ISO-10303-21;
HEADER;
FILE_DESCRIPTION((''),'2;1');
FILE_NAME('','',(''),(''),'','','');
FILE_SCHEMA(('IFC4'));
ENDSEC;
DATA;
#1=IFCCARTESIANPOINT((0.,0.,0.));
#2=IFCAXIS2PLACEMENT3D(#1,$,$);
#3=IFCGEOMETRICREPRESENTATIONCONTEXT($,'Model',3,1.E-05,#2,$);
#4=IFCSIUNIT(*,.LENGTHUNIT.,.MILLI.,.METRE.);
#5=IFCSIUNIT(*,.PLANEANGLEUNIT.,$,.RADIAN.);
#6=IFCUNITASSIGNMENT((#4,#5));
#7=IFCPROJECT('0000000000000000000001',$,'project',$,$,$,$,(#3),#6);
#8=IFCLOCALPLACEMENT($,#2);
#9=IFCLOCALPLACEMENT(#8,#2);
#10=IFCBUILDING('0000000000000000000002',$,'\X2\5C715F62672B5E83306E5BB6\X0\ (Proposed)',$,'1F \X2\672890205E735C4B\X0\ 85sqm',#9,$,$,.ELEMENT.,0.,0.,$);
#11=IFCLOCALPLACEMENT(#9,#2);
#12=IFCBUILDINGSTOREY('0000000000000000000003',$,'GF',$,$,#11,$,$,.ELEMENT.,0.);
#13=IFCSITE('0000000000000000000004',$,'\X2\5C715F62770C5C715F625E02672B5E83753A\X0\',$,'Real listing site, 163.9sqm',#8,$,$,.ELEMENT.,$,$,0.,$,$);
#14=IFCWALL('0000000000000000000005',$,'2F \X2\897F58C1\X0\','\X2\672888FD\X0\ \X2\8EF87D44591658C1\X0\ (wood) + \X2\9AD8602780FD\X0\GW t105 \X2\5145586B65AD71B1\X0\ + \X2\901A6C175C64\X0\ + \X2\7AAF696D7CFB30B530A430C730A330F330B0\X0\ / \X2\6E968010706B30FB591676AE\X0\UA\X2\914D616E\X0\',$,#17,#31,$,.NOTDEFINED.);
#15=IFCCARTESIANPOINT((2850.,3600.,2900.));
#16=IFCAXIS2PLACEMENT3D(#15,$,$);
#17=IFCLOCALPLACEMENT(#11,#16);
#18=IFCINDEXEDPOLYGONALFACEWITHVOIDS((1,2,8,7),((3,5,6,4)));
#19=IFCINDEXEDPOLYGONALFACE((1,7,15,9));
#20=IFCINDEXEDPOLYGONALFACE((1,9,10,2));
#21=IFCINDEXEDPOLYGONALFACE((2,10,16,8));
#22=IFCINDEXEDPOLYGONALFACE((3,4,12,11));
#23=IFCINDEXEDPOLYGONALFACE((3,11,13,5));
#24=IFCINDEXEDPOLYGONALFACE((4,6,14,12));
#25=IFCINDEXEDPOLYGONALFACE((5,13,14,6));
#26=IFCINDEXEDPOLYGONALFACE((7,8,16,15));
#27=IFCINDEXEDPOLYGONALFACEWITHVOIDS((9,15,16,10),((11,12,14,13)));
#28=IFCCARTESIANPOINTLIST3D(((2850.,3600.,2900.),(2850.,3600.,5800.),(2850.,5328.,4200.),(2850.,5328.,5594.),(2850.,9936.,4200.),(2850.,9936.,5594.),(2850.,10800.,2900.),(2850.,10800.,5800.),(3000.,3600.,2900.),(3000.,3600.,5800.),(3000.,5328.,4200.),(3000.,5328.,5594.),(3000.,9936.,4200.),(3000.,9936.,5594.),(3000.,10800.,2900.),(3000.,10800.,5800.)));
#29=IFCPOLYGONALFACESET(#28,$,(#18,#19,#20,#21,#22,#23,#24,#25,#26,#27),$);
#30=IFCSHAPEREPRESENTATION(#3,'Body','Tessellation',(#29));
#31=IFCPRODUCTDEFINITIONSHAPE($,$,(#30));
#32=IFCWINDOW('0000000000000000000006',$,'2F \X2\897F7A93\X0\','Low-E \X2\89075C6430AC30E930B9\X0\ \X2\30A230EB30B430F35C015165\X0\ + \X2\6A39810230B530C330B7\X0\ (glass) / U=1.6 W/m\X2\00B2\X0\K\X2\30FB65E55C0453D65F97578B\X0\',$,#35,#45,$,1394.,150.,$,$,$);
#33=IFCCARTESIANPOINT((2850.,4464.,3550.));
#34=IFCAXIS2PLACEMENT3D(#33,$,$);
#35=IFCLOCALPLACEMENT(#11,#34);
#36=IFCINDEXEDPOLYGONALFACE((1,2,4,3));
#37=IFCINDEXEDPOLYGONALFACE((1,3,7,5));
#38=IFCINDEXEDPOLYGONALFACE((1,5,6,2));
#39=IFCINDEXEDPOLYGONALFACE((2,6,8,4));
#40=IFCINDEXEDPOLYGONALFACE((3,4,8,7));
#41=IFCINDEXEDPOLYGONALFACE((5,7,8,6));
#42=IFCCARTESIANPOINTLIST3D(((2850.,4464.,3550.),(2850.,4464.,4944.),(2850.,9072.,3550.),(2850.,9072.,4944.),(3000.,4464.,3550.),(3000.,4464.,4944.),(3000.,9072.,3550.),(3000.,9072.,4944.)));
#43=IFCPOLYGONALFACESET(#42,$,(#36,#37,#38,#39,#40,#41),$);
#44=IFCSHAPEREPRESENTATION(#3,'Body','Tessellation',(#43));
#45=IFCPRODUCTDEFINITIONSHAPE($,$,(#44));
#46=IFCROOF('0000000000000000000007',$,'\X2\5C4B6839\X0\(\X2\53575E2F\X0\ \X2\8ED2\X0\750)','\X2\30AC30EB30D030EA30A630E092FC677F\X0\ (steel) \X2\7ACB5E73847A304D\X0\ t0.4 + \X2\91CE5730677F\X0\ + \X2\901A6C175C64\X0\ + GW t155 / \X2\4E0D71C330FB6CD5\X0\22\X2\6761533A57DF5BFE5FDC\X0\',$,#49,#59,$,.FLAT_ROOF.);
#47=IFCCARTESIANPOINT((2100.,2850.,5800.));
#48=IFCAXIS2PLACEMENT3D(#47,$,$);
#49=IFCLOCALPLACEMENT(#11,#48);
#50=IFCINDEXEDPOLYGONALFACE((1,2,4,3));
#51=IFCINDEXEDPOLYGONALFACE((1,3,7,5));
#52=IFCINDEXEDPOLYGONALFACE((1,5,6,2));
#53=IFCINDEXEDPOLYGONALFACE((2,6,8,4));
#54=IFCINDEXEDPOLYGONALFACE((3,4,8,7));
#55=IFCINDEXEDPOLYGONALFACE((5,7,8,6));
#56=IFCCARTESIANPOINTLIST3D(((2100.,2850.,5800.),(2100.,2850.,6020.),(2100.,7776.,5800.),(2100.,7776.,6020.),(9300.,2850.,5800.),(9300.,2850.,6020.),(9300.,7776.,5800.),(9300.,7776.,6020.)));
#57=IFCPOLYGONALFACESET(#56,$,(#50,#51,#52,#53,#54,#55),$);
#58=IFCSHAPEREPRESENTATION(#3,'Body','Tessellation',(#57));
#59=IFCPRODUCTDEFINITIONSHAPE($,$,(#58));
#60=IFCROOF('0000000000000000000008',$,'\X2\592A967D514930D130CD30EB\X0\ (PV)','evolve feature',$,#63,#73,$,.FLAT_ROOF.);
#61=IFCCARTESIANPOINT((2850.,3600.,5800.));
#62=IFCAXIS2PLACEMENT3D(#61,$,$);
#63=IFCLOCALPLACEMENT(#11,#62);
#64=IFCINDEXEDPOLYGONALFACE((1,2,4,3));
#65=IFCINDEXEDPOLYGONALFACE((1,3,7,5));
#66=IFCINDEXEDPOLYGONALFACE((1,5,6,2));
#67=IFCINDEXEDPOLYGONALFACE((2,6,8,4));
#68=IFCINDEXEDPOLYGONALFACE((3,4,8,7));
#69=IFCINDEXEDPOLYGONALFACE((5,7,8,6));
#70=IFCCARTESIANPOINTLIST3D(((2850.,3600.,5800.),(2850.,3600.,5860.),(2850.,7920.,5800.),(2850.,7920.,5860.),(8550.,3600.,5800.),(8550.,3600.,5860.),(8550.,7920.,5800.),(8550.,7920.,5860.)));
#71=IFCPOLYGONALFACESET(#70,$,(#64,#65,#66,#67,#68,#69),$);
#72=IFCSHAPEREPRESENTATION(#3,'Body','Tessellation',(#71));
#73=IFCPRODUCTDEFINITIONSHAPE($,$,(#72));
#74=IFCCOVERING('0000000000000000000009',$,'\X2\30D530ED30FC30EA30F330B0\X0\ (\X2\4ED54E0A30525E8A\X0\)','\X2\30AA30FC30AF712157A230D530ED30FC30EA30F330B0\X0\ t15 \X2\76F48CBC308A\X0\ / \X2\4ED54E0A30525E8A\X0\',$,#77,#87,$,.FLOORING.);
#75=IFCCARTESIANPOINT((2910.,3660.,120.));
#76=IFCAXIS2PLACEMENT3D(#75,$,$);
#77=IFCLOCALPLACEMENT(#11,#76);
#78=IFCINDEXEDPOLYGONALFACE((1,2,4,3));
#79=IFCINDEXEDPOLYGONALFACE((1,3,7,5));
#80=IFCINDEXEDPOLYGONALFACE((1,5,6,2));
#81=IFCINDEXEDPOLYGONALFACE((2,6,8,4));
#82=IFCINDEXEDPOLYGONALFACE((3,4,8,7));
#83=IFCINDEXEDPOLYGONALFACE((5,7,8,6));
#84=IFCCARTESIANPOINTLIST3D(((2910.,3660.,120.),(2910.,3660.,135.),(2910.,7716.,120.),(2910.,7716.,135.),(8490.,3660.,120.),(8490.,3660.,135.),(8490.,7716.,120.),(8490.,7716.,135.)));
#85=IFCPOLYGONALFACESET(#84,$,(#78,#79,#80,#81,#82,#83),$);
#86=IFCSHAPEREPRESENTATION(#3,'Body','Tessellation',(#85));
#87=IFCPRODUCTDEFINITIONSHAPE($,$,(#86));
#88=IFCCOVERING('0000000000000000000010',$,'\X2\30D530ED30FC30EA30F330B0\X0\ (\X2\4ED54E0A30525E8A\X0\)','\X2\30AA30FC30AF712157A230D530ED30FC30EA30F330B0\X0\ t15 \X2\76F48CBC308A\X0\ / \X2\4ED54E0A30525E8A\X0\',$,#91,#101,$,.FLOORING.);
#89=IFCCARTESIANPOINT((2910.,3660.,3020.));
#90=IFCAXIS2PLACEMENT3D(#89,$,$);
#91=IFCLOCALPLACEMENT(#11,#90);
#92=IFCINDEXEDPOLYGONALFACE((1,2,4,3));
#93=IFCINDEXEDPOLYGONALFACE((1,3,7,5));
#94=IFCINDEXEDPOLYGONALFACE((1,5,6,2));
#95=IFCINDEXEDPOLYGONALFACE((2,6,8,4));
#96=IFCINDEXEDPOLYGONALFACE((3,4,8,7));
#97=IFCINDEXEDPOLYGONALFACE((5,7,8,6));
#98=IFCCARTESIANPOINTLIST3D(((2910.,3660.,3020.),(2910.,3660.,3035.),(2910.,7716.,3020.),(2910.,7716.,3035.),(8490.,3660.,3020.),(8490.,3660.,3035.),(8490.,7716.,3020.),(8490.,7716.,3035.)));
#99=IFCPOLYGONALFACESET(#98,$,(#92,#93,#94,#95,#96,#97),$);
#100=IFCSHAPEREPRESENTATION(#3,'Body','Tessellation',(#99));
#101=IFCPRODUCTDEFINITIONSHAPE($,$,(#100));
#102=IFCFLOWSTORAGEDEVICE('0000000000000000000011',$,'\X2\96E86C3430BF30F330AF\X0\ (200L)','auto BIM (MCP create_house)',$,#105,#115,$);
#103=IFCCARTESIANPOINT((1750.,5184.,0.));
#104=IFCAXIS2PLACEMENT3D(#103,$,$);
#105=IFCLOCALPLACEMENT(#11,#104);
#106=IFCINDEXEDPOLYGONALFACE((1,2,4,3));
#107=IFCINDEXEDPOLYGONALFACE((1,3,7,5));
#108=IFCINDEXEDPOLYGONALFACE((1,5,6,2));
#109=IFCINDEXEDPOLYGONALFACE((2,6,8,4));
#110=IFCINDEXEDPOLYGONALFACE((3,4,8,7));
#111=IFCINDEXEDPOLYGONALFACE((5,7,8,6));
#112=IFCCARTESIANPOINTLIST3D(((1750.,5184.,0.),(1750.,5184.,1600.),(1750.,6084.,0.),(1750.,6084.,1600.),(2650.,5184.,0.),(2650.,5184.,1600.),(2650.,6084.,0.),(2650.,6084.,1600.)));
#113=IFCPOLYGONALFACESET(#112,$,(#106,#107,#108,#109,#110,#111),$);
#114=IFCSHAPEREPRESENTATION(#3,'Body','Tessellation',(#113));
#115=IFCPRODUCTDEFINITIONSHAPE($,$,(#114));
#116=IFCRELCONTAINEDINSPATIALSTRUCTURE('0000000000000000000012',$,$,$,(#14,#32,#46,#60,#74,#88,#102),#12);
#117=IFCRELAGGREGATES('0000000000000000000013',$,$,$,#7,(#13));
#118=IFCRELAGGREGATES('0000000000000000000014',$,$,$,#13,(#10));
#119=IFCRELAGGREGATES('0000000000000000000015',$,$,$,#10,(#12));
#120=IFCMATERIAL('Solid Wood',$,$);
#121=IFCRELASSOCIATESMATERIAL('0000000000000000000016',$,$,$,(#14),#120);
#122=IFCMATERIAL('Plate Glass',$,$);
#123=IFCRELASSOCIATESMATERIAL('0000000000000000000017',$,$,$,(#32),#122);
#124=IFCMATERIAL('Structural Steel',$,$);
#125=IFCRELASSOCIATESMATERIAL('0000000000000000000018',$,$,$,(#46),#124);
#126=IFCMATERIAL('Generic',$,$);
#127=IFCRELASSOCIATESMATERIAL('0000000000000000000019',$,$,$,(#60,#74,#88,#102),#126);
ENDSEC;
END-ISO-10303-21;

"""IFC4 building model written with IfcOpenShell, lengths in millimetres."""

from ifc_helpers import new_model, si_unit, frame, frame_2d, origin, place, context, project, spatial, rectangle, extrude, material, element, fill, save


model = new_model("IFC4")

# Units and contexts
model_context = context("Model", 3, precision=1e-05, world=origin())
ifc_project = project(units=[si_unit("LENGTHUNIT", "METRE", prefix="MILLI"), si_unit("PLANEANGLEUNIT", "RADIAN")], contexts=[model_context])

# Site, building, storey
site_placement = place(None, origin())
site = spatial("IfcSite", under=ifc_project, at=site_placement, Name="山形県山形市末広町", ObjectType="Real listing site, 163.9sqm", CompositionType="ELEMENT", RefElevation=0.0)
building_placement = place(site_placement, origin())
building = spatial("IfcBuilding", under=site, at=building_placement, Name="山形末広の家 (Proposed)", ObjectType="1F 木造平屋 85sqm", CompositionType="ELEMENT", ElevationOfRefHeight=0.0, ElevationOfTerrain=0.0)
storey_placement = place(building_placement, origin())
storey = spatial("IfcBuildingStorey", under=building, at=storey_placement, Name="GF", CompositionType="ELEMENT", Elevation=0.0)

# Shared definitions
ifc_material_1 = material(Name="Solid Wood")
ifc_material_2 = material(Name="Generic")

# Shared definitions
ifc_material_3 = material(Name="Plate Glass")

# Wall, opening, window
wall_1_placement = place(storey_placement, frame((2850.0, 3600.0, 2900.0)))
wall_1 = element("IfcWall", 1, at=wall_1_placement, inside=storey, material=ifc_material_1, Name="2F 西壁", Description="木製 軸組外壁 (wood) + 高性能GW t105 充填断熱 + 通気層 + 窯業系サイディング / 準耐火・外皮UA配慮", PredefinedType="NOTDEFINED", context=model_context, shape_type="SweptSolid", body=[
    extrude(rectangle(XDim=150.0, YDim=7200.0, at=frame_2d((75.0, 3600.0))), frame((2850.0, 3600.0, 2900.0)), (0.0, 0.0, 1.0), 2900.0),
])
opening_1_placement = place(storey_placement, frame((2850.0, 4464.0, 3550.0)))
opening_1 = element("IfcOpeningElement", 2, at=opening_1_placement, cuts=wall_1, PredefinedType="NOTDEFINED", context=model_context, shape_type="SweptSolid", body=[
    extrude(rectangle(XDim=150.0, YDim=4608.0, at=frame_2d((75.0, 2304.0))), frame((2850.0, 4464.0, 3550.0)), (0.0, 0.0, 1.0), 1394.0),
])
window_1_placement = place(storey_placement, frame((2850.0, 4464.0, 3550.0)))
window_1 = element("IfcWindow", 3, at=window_1_placement, inside=storey, material=ifc_material_3, Name="2F 西窓", Description="Low-E 複層ガラス アルゴン封入 + 樹脂サッシ (glass) / U=1.6 W/m²K・日射取得型", OverallHeight=1394.0, OverallWidth=150.0, context=model_context, shape_type="SweptSolid", body=[
    extrude(rectangle(XDim=150.0, YDim=4608.0, at=frame_2d((75.0, 2304.0))), frame((2850.0, 4464.0, 3550.0)), (0.0, 0.0, 1.0), 1394.0),
])
fill(opening_1, window_1)

# Roofs
ifc_material_4 = material(Name="Structural Steel")
for number, where, name in (
    (4, (2100.0, 2850.0, 5800.0), "屋根(南帯 軒750)"),
):
    element("IfcRoof", number, at=place(storey_placement, frame(where)), inside=storey, material=ifc_material_4, Name=name, Description="ガルバリウム鋼板 (steel) 立平葺き t0.4 + 野地板 + 通気層 + GW t155 / 不燃・法22条区域対応", PredefinedType="FLAT_ROOF", context=model_context, shape_type="SweptSolid", body=[
        extrude(rectangle(XDim=7200.0, YDim=4926.0, at=frame_2d((3600.0, 2463.0))), frame((2100.0, 2850.0, 5800.0)), (0.0, 0.0, 1.0), 220.0),
    ])
roof_placement = place(storey_placement, frame((2850.0, 3600.0, 5800.0)))
element("IfcRoof", 5, at=roof_placement, inside=storey, material=ifc_material_2, Name="太陽光パネル (PV)", Description="evolve feature", PredefinedType="FLAT_ROOF", context=model_context, shape_type="SweptSolid", body=[
    extrude(rectangle(XDim=5700.0, YDim=4320.0, at=frame_2d((2850.0, 2160.0))), frame((2850.0, 3600.0, 5800.0)), (0.0, 0.0, 1.0), 60.0),
])

# Coverings
covering_1_placement = place(storey_placement, frame((2910.0, 3660.0, 120.0)))
element("IfcCovering", 6, at=covering_1_placement, inside=storey, material=ifc_material_2, Name="フローリング (仕上げ床)", Description="オーク無垢フローリング t15 直貼り / 仕上げ床", PredefinedType="FLOORING", context=model_context, shape_type="SweptSolid", body=[
    extrude(rectangle(XDim=5580.0, YDim=4056.0, at=frame_2d((2790.0, 2028.0))), frame((2910.0, 3660.0, 120.0)), (0.0, 0.0, 1.0), 15.0),
])
covering_2_placement = place(storey_placement, frame((2910.0, 3660.0, 3020.0)))
element("IfcCovering", 7, at=covering_2_placement, inside=storey, material=ifc_material_2, Name="フローリング (仕上げ床)", Description="オーク無垢フローリング t15 直貼り / 仕上げ床", PredefinedType="FLOORING", context=model_context, shape_type="SweptSolid", body=[
    extrude(rectangle(XDim=5580.0, YDim=4056.0, at=frame_2d((2790.0, 2028.0))), frame((2910.0, 3660.0, 3020.0)), (0.0, 0.0, 1.0), 15.0),
])

# Flow storage device
flow_storage_device_placement = place(storey_placement, frame((1750.0, 5184.0, 0.0)))
element("IfcFlowStorageDevice", 8, at=flow_storage_device_placement, inside=storey, material=ifc_material_2, Name="雨水タンク (200L)", Description="auto BIM (MCP create_house)", context=model_context, shape_type="SweptSolid", body=[
    extrude(rectangle(XDim=900.0, YDim=900.0, at=frame_2d((450.0, 450.0))), frame((1750.0, 5184.0, 0.0)), (0.0, 0.0, 1.0), 1600.0),
])

save(model, "model.ifc")
